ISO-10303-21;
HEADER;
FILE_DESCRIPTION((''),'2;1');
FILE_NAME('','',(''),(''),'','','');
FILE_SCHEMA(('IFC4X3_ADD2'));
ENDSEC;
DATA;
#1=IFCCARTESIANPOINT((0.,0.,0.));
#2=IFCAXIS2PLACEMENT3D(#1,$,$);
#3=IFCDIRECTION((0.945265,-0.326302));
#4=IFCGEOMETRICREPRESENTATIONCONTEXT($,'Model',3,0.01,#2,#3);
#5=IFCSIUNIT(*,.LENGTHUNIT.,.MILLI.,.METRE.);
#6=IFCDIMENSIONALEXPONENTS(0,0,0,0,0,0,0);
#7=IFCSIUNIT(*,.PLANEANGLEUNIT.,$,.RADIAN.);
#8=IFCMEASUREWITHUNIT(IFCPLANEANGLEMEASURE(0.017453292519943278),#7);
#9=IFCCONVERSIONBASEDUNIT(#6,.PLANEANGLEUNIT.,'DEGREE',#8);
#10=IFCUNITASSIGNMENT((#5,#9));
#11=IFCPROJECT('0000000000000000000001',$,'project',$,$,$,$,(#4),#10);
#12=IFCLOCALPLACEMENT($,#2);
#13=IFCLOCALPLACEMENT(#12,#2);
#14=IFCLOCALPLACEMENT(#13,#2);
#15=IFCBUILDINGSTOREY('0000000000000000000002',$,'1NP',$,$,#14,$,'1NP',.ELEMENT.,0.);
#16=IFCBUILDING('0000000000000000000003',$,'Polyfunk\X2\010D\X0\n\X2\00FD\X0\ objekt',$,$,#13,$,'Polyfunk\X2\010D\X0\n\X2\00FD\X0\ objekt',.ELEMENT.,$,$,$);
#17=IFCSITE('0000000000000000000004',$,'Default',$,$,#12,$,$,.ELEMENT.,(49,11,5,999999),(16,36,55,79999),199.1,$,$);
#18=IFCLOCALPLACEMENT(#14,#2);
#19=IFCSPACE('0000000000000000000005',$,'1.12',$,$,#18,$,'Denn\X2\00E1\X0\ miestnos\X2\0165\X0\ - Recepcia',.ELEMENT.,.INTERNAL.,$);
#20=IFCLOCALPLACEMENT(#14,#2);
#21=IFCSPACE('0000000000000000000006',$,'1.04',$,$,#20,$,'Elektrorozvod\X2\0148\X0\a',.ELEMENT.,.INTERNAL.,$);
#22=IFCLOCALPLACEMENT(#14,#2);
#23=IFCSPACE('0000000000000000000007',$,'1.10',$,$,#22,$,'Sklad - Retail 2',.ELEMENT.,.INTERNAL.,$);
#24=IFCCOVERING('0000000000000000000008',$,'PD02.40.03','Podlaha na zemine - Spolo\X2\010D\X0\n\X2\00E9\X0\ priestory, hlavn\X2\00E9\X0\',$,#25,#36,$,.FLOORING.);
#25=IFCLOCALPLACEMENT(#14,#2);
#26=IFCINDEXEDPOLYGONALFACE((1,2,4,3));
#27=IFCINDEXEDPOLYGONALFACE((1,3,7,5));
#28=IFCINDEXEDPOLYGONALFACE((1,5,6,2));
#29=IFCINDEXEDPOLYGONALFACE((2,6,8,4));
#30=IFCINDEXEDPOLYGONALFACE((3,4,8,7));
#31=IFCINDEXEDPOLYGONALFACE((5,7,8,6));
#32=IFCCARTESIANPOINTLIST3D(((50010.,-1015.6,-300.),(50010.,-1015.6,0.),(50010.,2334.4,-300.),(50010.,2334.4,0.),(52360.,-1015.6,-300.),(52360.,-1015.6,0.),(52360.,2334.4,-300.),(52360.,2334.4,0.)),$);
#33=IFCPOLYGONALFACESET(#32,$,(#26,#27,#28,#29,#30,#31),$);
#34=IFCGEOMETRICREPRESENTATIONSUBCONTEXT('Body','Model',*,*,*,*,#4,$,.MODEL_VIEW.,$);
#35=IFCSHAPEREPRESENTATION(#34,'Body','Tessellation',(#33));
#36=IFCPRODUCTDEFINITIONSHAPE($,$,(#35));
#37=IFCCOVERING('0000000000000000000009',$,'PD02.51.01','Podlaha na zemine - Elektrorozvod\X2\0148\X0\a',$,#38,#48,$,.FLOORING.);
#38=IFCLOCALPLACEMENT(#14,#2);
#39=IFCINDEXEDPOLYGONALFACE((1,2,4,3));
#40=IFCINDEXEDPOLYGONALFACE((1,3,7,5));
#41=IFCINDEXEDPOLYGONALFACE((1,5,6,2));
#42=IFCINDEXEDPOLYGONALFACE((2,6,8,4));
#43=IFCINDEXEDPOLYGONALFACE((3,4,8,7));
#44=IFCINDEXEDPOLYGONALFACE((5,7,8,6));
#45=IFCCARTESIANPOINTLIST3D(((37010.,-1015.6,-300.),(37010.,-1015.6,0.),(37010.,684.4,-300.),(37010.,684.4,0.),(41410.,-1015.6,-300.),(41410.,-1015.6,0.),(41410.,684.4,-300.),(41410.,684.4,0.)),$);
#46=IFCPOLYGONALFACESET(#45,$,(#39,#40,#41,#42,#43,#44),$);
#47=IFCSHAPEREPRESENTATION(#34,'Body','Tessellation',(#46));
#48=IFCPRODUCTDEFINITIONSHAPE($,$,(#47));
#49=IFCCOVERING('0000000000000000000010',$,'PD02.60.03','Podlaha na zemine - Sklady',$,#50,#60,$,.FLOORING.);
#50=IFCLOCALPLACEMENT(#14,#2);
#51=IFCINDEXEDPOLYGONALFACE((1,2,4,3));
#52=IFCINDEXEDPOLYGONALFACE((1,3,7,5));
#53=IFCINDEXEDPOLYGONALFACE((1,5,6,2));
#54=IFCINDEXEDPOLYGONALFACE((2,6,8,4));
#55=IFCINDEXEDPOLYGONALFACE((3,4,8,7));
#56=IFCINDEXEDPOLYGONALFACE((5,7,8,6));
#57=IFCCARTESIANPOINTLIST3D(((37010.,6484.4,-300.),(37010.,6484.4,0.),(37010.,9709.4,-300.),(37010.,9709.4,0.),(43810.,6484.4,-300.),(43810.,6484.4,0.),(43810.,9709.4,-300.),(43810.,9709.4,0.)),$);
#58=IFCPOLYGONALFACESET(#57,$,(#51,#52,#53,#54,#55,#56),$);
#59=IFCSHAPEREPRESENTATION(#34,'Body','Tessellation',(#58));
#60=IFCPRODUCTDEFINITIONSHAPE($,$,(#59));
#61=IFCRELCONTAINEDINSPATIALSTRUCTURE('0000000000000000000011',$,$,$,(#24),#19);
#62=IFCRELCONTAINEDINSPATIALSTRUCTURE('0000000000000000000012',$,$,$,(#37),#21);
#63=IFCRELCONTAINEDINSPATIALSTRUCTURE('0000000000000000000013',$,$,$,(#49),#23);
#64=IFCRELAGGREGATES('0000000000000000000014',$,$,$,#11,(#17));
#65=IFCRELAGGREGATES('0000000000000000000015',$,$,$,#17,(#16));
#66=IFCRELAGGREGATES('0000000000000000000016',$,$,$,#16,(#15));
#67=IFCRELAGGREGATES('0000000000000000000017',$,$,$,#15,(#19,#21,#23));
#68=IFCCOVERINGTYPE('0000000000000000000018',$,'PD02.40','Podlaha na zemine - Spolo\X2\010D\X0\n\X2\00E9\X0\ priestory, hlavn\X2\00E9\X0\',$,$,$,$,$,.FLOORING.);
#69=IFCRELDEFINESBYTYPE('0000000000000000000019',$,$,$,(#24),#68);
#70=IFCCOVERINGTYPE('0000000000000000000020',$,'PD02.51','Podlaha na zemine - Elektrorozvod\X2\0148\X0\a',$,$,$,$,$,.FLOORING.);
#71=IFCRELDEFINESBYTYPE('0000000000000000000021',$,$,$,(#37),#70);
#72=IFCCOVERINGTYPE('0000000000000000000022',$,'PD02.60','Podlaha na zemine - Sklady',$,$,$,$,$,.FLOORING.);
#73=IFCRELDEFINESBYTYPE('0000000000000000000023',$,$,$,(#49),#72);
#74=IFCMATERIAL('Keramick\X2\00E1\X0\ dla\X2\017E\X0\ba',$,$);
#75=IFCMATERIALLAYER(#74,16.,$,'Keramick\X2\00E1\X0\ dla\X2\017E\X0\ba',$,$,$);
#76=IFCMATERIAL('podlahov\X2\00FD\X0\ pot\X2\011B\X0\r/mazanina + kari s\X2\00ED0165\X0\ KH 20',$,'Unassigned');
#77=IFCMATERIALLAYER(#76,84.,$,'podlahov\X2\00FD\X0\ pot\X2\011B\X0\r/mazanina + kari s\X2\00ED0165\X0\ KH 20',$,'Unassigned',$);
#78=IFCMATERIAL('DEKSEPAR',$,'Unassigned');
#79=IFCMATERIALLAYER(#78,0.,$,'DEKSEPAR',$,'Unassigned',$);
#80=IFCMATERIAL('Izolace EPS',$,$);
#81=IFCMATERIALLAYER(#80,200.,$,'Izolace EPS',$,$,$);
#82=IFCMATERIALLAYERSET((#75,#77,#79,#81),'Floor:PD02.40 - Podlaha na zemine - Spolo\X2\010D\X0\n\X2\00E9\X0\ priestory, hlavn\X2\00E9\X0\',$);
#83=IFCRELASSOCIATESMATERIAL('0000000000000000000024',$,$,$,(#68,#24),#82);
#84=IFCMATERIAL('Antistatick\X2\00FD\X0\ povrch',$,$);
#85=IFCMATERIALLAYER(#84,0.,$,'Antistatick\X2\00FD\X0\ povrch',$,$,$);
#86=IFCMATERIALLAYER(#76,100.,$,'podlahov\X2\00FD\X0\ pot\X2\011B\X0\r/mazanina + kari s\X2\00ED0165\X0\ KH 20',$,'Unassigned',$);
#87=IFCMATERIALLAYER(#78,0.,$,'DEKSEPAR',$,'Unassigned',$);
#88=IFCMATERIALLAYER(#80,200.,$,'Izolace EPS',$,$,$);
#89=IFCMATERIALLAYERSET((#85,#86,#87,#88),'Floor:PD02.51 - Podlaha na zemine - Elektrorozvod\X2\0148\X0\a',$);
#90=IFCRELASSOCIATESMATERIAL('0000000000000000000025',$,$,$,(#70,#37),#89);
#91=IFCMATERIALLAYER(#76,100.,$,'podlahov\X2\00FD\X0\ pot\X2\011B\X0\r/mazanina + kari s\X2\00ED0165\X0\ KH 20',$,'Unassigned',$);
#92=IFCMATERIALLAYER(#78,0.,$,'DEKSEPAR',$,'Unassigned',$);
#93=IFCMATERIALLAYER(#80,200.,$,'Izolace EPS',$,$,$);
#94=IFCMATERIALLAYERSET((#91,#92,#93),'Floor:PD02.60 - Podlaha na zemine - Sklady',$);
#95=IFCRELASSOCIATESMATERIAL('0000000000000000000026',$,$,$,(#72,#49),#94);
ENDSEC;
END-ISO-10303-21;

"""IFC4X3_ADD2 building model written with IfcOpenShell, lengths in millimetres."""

from ifc_helpers import new_model, entity, si_unit, converted_unit, direction, frame, frame_2d, origin, origin_2d_with_axis, place, context, subcontext, project, spatial, rectangle, extrude, material, layer, layer_set, layer_usage, type_object, element, save


model = new_model("IFC4X3_ADD2")

# Units and contexts
model_context = context("Model", 3, precision=0.01, world=origin(), true_north=direction((0.945265, -0.326302)))
body_context = subcontext(model_context, "Body", "Model", "MODEL_VIEW")
ifc_project = project(units=[si_unit("LENGTHUNIT", "METRE", prefix="MILLI"), converted_unit("PLANEANGLEUNIT", "DEGREE", entity("IfcPlaneAngleMeasure", 0.017453292519943278), si_unit("PLANEANGLEUNIT", "RADIAN"), dimensions=[0, 0, 0, 0, 0, 0, 0])], contexts=[model_context])

# Site, building, storey
site_placement = place(None, origin())
site = spatial("IfcSite", under=ifc_project, at=site_placement, Name="Default", CompositionType="ELEMENT", RefLatitude=(49, 11, 5, 999999), RefLongitude=(16, 36, 55, 79999), RefElevation=199.1)
building_placement = place(site_placement, origin())
building = spatial("IfcBuilding", under=site, at=building_placement, Name="Polyfunkčný objekt", LongName="Polyfunkčný objekt", CompositionType="ELEMENT")
storey_placement = place(building_placement, origin())
storey = spatial("IfcBuildingStorey", under=building, at=storey_placement, Name="1NP", LongName="1NP", CompositionType="ELEMENT", Elevation=0.0)

# Shared definitions
ifc_material_1 = material(Name="podlahový potěr/mazanina + kari síť KH 20", Category="Unassigned")
ifc_material_2 = material(Name="DEKSEPAR", Category="Unassigned")
ifc_material_3 = material(Name="Izolace EPS")

# Shared definitions
ifc_material_4 = material(Name="Keramická dlažba")

# Shared definitions
ifc_layer_1 = layer(ifc_material_4, 16.0, Name="Keramická dlažba")
ifc_layer_2 = layer(ifc_material_1, 84.0, Name="podlahový potěr/mazanina + kari síť KH 20", Category="Unassigned")
ifc_layer_3 = layer(ifc_material_2, 0.0, Name="DEKSEPAR", Category="Unassigned")
ifc_layer_4 = layer(ifc_material_3, 200.0, Name="Izolace EPS")
ifc_layer_set_1 = layer_set([ifc_layer_1, ifc_layer_2, ifc_layer_3, ifc_layer_4], Name="Floor:PD02.40 - Podlaha na zemine - Spoločné priestory, hlavné")
covering_type_1 = type_object("IfcCoveringType", Name="PD02.40", Description="Podlaha na zemine - Spoločné priestory, hlavné", PredefinedType="FLOORING", material=ifc_layer_set_1)

# Shared definitions
space_1_placement = place(storey_placement, origin())
space_1 = spatial("IfcSpace", under=storey, at=space_1_placement, Name="1.12", LongName="Denná miestnosť - Recepcia", CompositionType="ELEMENT", PredefinedType="INTERNAL")

# Covering
ifc_layer_usage_1 = layer_usage(ifc_layer_set_1, "AXIS3", "POSITIVE", 0.0)
covering_1_placement = place(storey_placement, origin())
element("IfcCovering", 1, at=covering_1_placement, inside=space_1, type_object=covering_type_1, material=ifc_layer_usage_1, Name="PD02.40.03", Description="Podlaha na zemine - Spoločné priestory, hlavné", PredefinedType="FLOORING", context=body_context, shape_type="SweptSolid", body=[
    extrude(rectangle(XDim=3350.0, YDim=2350.0, at=frame_2d((0.0, 0.0), x_axis=(1.0, 0.0))), frame((51185.0, 659.4, 0.0), z_axis=(0.0, 0.0, -1.0), x_axis=(0.0, 1.0, 0.0)), (0.0, 0.0, 1.0), 300.0),
])

# Shared definitions
space_2_placement = place(storey_placement, origin())
space_2 = spatial("IfcSpace", under=storey, at=space_2_placement, Name="1.04", LongName="Elektrorozvodňa", CompositionType="ELEMENT", PredefinedType="INTERNAL")

# Covering
ifc_material_5 = material(Name="Antistatický povrch")
ifc_layer_5 = layer(ifc_material_5, 0.0, Name="Antistatický povrch")
ifc_layer_6 = layer(ifc_material_1, 100.0, Name="podlahový potěr/mazanina + kari síť KH 20", Category="Unassigned")
ifc_layer_7 = layer(ifc_material_2, 0.0, Name="DEKSEPAR", Category="Unassigned")
ifc_layer_8 = layer(ifc_material_3, 200.0, Name="Izolace EPS")
ifc_layer_set_2 = layer_set([ifc_layer_5, ifc_layer_6, ifc_layer_7, ifc_layer_8], Name="Floor:PD02.51 - Podlaha na zemine - Elektrorozvodňa")
ifc_layer_usage_2 = layer_usage(ifc_layer_set_2, "AXIS3", "POSITIVE", 0.0)
covering_type_2 = type_object("IfcCoveringType", Name="PD02.51", Description="Podlaha na zemine - Elektrorozvodňa", PredefinedType="FLOORING", material=ifc_layer_set_2)
covering_2_placement = place(storey_placement, origin())
element("IfcCovering", 2, at=covering_2_placement, inside=space_2, type_object=covering_type_2, material=ifc_layer_usage_2, Name="PD02.51.01", Description="Podlaha na zemine - Elektrorozvodňa", PredefinedType="FLOORING", context=body_context, shape_type="SweptSolid", body=[
    extrude(rectangle(XDim=1700.0, YDim=4400.0, at=frame_2d((0.0, 0.0), x_axis=(1.0, 0.0))), frame((39210.0, -165.6, 0.0), z_axis=(0.0, 0.0, -1.0), x_axis=(0.0, 1.0, 0.0)), (0.0, 0.0, 1.0), 300.0),
])

# Shared definitions
ifc_layer_9 = layer(ifc_material_1, 100.0, Name="podlahový potěr/mazanina + kari síť KH 20", Category="Unassigned")
ifc_layer_10 = layer(ifc_material_2, 0.0, Name="DEKSEPAR", Category="Unassigned")
ifc_layer_11 = layer(ifc_material_3, 200.0, Name="Izolace EPS")
ifc_layer_set_3 = layer_set([ifc_layer_9, ifc_layer_10, ifc_layer_11], Name="Floor:PD02.60 - Podlaha na zemine - Sklady")
covering_type_3 = type_object("IfcCoveringType", Name="PD02.60", Description="Podlaha na zemine - Sklady", PredefinedType="FLOORING", material=ifc_layer_set_3)

# Shared definitions
space_3_placement = place(storey_placement, origin())
space_3 = spatial("IfcSpace", under=storey, at=space_3_placement, Name="1.10", LongName="Sklad - Retail 2", CompositionType="ELEMENT", PredefinedType="INTERNAL")

# Covering
ifc_layer_usage_3 = layer_usage(ifc_layer_set_3, "AXIS3", "POSITIVE", 0.0)
covering_3_placement = place(storey_placement, origin())
element("IfcCovering", 3, at=covering_3_placement, inside=space_3, type_object=covering_type_3, material=ifc_layer_usage_3, Name="PD02.60.03", Description="Podlaha na zemine - Sklady", PredefinedType="FLOORING", context=body_context, shape_type="SweptSolid", body=[
    extrude(rectangle(XDim=3225.0, YDim=6800.0, at=origin_2d_with_axis()), frame((40410.0, 8096.9, 0.0), z_axis=(0.0, 0.0, -1.0), x_axis=(0.0, 1.0, 0.0)), (0.0, 0.0, 1.0), 300.0),
])

save(model, "model.ifc")
